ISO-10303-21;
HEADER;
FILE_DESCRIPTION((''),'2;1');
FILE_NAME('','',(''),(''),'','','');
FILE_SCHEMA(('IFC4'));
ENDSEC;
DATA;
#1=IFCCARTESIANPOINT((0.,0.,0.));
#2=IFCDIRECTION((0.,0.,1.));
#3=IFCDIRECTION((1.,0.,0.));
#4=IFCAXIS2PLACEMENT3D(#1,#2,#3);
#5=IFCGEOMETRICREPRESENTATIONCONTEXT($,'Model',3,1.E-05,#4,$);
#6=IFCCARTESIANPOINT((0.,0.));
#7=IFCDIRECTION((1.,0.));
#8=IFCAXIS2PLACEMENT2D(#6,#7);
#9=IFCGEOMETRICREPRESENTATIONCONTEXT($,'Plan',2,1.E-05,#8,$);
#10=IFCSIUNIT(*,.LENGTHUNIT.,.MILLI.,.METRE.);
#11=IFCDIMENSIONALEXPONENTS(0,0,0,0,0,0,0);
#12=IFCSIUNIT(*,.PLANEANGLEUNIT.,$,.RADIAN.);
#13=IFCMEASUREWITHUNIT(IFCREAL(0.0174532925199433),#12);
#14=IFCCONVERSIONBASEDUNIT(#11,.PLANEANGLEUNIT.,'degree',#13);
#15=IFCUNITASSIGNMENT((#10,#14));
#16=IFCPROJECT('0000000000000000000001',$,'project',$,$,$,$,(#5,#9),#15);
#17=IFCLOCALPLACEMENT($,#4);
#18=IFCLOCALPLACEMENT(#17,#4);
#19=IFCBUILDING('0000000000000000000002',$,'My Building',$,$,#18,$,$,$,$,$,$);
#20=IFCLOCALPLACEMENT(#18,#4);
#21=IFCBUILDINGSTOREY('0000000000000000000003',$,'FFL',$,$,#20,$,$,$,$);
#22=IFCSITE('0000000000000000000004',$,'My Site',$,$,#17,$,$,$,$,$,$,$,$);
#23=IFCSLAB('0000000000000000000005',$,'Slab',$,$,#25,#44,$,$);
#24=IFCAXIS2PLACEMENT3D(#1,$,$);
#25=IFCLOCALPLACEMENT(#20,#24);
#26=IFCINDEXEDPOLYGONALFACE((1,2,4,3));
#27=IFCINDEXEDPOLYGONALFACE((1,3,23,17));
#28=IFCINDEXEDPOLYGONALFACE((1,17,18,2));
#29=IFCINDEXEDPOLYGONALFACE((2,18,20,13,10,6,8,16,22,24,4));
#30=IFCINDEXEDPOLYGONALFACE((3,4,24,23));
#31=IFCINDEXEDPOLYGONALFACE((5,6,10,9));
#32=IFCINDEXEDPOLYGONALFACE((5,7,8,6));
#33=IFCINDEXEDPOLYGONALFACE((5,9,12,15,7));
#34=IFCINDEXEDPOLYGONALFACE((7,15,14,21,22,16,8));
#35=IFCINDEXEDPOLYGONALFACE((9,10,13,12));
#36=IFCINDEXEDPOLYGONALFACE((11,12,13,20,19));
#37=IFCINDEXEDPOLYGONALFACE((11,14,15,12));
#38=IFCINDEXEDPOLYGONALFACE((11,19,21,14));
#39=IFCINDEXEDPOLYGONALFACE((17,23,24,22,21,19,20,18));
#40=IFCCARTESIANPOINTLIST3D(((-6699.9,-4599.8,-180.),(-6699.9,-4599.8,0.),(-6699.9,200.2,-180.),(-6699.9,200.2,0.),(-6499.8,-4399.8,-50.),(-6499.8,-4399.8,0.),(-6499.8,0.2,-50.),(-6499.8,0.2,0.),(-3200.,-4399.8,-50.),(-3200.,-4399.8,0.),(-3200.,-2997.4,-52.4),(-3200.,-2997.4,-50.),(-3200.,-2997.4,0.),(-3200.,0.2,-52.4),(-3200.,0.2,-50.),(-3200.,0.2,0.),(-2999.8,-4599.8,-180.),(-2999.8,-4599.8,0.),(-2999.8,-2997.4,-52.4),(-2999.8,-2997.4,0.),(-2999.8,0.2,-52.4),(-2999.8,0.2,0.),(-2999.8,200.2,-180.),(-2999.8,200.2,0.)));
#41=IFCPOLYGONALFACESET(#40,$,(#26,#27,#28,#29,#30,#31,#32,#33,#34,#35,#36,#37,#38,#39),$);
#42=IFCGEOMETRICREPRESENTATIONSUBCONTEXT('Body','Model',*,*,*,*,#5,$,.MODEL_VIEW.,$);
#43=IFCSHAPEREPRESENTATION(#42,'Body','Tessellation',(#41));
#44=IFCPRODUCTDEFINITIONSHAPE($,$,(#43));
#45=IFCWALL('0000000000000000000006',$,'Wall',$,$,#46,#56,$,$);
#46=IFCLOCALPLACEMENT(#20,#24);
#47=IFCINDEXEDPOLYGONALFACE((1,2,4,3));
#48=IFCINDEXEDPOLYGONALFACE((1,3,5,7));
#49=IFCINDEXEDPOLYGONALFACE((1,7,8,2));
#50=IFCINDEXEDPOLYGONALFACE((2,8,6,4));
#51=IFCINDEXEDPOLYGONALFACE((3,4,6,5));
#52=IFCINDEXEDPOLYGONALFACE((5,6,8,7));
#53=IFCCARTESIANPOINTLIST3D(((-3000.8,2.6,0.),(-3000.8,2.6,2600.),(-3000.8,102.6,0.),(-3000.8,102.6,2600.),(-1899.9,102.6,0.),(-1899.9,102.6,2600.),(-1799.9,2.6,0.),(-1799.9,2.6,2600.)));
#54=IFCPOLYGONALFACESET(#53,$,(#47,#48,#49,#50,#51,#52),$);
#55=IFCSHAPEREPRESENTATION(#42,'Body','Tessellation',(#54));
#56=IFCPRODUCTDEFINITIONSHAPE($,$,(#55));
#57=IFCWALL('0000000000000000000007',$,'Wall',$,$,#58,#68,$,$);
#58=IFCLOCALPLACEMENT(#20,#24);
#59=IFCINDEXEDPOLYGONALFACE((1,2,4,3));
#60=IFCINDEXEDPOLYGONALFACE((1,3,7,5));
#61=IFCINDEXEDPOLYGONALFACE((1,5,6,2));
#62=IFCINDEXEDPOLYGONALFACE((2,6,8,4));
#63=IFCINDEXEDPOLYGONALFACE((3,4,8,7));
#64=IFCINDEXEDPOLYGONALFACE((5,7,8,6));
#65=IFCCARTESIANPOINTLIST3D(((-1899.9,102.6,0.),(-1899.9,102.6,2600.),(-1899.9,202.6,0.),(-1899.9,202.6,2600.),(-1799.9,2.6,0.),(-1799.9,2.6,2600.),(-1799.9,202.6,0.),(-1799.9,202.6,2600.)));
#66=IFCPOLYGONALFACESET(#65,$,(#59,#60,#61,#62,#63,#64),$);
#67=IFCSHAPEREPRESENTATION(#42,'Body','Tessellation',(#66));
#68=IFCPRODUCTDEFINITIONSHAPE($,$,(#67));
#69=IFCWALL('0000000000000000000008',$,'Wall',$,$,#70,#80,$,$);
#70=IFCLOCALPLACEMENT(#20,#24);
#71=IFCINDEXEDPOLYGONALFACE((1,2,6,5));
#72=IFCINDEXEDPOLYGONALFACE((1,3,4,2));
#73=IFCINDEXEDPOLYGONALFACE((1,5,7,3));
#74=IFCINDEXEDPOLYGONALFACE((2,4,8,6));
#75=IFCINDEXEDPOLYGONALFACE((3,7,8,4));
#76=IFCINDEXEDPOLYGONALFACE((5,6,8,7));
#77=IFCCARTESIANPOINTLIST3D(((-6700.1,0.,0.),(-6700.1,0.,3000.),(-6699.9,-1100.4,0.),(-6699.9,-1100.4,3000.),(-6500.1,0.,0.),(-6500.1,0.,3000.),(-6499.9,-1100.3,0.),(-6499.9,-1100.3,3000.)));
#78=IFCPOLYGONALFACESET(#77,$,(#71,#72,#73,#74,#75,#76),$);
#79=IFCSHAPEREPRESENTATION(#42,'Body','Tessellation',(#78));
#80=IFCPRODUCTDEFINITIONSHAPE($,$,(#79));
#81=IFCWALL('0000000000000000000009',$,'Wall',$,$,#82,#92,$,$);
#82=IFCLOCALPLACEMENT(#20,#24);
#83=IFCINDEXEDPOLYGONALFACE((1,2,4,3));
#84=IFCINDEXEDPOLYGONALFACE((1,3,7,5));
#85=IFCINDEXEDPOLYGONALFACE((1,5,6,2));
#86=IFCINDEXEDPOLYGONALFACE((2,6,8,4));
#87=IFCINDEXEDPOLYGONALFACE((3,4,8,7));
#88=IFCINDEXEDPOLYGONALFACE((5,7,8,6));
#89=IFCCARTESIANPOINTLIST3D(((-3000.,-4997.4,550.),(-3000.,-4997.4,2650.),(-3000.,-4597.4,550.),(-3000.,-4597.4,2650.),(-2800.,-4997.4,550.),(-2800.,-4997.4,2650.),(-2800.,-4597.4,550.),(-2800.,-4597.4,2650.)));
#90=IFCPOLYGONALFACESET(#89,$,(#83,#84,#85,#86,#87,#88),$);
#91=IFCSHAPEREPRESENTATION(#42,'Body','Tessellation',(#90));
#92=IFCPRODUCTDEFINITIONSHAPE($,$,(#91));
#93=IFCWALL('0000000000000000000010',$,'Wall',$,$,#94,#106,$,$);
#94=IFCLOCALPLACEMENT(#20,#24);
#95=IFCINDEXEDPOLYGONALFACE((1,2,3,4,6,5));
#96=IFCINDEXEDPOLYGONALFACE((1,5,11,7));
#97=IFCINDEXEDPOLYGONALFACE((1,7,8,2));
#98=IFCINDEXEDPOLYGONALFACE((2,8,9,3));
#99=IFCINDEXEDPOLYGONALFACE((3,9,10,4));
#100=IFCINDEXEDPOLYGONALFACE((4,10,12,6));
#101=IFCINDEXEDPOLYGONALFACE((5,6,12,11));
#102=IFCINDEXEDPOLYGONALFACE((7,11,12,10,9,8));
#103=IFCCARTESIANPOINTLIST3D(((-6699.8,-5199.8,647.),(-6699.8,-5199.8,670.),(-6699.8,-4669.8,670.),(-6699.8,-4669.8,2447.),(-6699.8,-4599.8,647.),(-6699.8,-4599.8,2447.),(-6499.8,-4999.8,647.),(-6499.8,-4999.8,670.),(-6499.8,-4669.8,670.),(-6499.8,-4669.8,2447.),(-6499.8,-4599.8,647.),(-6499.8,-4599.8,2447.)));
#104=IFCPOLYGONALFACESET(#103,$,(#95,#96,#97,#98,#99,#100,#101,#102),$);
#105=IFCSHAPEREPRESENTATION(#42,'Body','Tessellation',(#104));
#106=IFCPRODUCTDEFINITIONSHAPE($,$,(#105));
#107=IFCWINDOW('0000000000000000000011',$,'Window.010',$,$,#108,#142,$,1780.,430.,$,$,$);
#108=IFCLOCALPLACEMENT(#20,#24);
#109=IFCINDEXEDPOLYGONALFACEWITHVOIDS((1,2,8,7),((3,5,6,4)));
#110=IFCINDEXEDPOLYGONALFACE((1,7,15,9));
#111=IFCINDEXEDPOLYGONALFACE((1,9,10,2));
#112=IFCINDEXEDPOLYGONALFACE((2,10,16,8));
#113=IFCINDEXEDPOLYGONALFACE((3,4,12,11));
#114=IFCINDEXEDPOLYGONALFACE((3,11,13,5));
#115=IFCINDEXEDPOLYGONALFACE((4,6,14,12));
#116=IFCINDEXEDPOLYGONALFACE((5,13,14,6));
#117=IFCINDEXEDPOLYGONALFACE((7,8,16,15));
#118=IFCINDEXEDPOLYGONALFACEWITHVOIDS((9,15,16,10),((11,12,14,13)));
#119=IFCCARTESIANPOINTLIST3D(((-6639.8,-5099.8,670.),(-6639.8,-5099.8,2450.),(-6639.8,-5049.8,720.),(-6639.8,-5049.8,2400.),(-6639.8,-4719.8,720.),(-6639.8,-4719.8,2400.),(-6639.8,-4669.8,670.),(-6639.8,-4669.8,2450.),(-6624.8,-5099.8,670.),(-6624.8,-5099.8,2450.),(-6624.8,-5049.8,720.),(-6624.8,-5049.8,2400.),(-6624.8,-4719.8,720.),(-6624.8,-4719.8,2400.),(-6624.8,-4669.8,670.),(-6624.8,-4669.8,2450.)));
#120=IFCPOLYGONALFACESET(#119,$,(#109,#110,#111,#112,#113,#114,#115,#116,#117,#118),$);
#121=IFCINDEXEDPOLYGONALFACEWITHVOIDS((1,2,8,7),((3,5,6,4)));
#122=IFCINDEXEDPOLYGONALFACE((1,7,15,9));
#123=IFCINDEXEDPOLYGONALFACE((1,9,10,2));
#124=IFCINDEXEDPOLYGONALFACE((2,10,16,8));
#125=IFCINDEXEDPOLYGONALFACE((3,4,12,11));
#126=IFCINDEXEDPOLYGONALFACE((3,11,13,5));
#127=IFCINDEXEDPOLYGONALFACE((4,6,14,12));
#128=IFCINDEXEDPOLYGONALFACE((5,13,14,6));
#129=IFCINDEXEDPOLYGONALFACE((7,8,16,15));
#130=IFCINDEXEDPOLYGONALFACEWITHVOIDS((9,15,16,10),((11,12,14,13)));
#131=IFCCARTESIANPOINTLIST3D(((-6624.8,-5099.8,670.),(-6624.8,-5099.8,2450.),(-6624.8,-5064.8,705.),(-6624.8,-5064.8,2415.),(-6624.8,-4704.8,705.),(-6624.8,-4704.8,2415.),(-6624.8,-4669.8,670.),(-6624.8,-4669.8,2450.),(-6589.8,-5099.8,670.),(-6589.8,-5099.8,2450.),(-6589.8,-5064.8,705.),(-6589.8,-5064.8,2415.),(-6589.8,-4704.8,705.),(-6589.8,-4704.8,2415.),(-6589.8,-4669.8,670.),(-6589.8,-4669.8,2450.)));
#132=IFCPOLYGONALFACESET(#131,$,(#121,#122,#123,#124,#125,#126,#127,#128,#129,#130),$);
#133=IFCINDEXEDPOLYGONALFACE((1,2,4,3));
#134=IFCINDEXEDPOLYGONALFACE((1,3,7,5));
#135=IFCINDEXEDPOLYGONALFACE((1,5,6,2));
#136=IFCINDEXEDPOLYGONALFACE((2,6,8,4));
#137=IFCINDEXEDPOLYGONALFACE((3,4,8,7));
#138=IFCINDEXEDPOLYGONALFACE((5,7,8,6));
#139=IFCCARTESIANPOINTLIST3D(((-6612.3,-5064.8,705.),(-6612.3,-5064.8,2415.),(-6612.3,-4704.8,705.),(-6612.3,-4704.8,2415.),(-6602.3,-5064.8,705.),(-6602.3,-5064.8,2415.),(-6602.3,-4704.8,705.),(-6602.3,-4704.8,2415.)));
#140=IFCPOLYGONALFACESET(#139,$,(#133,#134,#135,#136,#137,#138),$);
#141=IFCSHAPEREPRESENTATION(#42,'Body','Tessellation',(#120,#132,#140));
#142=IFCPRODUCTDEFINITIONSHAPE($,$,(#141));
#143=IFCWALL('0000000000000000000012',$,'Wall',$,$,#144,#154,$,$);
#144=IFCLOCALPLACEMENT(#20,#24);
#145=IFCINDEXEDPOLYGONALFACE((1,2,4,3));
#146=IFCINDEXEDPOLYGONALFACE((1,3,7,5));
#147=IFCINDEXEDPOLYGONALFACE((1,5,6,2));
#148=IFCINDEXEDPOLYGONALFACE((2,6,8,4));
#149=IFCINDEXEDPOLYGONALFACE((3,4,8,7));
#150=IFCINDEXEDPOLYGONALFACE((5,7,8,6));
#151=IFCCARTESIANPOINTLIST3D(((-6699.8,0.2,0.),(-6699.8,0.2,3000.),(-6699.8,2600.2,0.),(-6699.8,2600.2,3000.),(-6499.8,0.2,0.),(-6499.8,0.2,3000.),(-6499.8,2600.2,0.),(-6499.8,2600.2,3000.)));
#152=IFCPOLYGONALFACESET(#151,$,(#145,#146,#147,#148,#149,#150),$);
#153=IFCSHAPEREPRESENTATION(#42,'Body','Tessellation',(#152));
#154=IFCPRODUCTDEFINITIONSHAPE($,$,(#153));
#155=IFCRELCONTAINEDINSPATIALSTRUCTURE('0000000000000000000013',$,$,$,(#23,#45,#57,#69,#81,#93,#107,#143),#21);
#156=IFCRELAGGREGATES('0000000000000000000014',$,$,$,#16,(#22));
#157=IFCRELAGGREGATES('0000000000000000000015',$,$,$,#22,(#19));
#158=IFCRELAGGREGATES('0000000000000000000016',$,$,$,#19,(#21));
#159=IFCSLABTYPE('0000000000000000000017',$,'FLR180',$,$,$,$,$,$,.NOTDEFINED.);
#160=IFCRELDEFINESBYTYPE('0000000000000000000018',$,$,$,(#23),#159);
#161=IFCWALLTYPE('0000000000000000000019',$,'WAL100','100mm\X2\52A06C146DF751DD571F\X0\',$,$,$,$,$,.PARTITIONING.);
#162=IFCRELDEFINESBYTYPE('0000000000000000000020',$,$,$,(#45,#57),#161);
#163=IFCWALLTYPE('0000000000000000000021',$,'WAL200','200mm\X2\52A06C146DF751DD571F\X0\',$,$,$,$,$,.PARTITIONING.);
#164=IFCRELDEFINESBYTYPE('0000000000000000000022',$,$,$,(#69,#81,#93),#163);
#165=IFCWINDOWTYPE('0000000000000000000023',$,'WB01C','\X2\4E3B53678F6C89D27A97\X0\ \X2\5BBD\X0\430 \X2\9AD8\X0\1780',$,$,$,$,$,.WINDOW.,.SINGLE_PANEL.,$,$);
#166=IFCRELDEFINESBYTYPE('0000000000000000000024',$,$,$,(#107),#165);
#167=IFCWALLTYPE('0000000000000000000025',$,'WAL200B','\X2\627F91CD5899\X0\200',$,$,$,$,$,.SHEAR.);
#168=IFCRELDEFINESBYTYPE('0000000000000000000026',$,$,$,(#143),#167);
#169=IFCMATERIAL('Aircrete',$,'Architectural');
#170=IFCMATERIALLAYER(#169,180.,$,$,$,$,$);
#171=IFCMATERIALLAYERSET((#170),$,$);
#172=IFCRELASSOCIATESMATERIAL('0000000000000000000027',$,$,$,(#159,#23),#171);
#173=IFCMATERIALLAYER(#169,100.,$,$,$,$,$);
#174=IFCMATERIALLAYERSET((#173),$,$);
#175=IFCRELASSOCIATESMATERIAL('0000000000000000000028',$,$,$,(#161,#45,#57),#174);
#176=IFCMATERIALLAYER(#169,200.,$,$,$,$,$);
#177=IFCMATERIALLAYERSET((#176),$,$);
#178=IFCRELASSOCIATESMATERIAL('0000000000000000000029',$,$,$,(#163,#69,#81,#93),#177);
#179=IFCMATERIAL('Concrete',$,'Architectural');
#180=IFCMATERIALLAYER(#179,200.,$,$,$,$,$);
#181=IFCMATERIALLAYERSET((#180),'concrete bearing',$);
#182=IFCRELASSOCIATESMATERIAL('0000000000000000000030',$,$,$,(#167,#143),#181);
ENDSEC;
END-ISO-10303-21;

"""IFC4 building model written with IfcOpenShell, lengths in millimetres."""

from ifc_helpers import new_model, entity, si_unit, converted_unit, frame, origin_with_axes, origin_2d_with_axis, place, context, subcontext, project, spatial, line, indexed_curve, outline, extrude, shape, source, transform, mapped, material, layer, layer_set, layer_usage, type_object, type_shapes, element, fill, save


model = new_model("IFC4")

# Units and contexts
model_context = context("Model", 3, precision=1e-05, world=origin_with_axes())
plan_context = context("Plan", 2, precision=1e-05, world=origin_2d_with_axis())
body_context_1 = subcontext(model_context, "Body", "Model", "MODEL_VIEW")
body_context_2 = subcontext(plan_context, "Body", "Plan", "PLAN_VIEW")
ifc_project = project(units=[si_unit("LENGTHUNIT", "METRE", prefix="MILLI"), converted_unit("PLANEANGLEUNIT", "degree", entity("IfcReal", 0.0174532925199433), si_unit("PLANEANGLEUNIT", "RADIAN"), dimensions=[0, 0, 0, 0, 0, 0, 0])], contexts=[model_context, plan_context])

# Site, building, storey
site_placement = place(None, origin_with_axes())
site = spatial("IfcSite", under=ifc_project, at=site_placement, Name="My Site")
building_placement = place(site_placement, origin_with_axes())
building = spatial("IfcBuilding", under=site, at=building_placement, Name="My Building")
storey_placement = place(building_placement, origin_with_axes())
storey = spatial("IfcBuildingStorey", under=building, at=storey_placement, Name="FFL")

# Slab, openings
ifc_material_1 = material(Name="Aircrete", Category="Architectural")
ifc_layer_1 = layer(ifc_material_1, 180.0)
ifc_layer_set_1 = layer_set([ifc_layer_1])
ifc_layer_usage_1 = layer_usage(ifc_layer_set_1, "AXIS3", "POSITIVE", 0.0)
slab_type = type_object("IfcSlabType", Name="FLR180", PredefinedType="NOTDEFINED", material=ifc_layer_set_1)
slab_1_placement = place(storey_placement, frame((-6499.8, -4399.8, -180.0), z_axis=(0.0, 0.0, 1.0), x_axis=(1.0, 0.0, 0.0)))
slab_1 = element("IfcSlab", 1, at=slab_1_placement, inside=storey, type_object=slab_type, material=ifc_layer_usage_1, Name="Slab", context=body_context_1, shape_type="SweptSolid", body=[
    extrude(outline(indexed_curve([(-200.1, -200.0), (3500.0, -200.0), (3500.0, 4600.0), (-200.1, 4600.0), (-200.1, -200.0)])), None, (0.0, 0.0, 1.0), 180.0),
])
opening_1_placement = place(slab_1_placement, frame((0.0, 0.0, 130.0), z_axis=(0.0, 0.0, 1.0), x_axis=(1.0, 0.0, 0.0)))
element("IfcOpeningElement", 2, at=opening_1_placement, cuts=slab_1, PredefinedType="OPENING", context=body_context_1, shape_type="SweptSolid", body=[
    extrude(outline(indexed_curve([(0.0, 4400.0), (3299.8, 4400.0), (3299.8, 0.0), (0.0, 0.0), (0.0, 4400.0)])), origin_with_axes(), (0.0, 0.0, 1.0), 100.0),
])
opening_2_placement = place(slab_1_placement, frame((3299.8, 1402.4, 127.6), z_axis=(0.0, 0.0, 1.0), x_axis=(1.0, 0.0, 0.0)))
element("IfcOpeningElement", 3, at=opening_2_placement, cuts=slab_1, PredefinedType="OPENING", context=body_context_1, shape_type="SweptSolid", body=[
    extrude(outline(indexed_curve([(0.0, 2997.6), (200.3, 2997.6), (200.3, 0.0), (0.0, 0.0), (0.0, 2997.6)])), origin_with_axes(), (0.0, 0.0, 1.0), 100.0),
])

# Walls
ifc_layer_2 = layer(ifc_material_1, 100.0)
ifc_layer_set_2 = layer_set([ifc_layer_2])
ifc_layer_usage_2 = layer_usage(ifc_layer_set_2, "AXIS2", "POSITIVE", 0.0)
wall_type_1 = type_object("IfcWallType", Name="WAL100", Description="100mm加气混凝土", PredefinedType="PARTITIONING", material=ifc_layer_set_2)
wall_1_placement = place(storey_placement, frame((-3000.8, 2.6, 0.0), z_axis=(0.0, 0.0, 1.0), x_axis=(1.0, 0.0, 0.0)))
element("IfcWall", 4, at=wall_1_placement, inside=storey, type_object=wall_type_1, material=ifc_layer_usage_2, Name="Wall", context=body_context_1, shape_type="SweptSolid", body=[
    extrude(outline(indexed_curve([(0.0, 0.0), (0.0, 100.0), (1100.9, 100.0), (1200.9, 0.0)], segments=[line(1, 2, 3, 4, 1)])), origin_with_axes(), (0.0, 0.0, 1.0), 2600.0),
])
ifc_layer_usage_3 = layer_usage(ifc_layer_set_2, "AXIS2", "POSITIVE", 0.0)
wall_2_placement = place(storey_placement, frame((-1799.9, 2.6, 0.0), z_axis=(0.0, 0.0, 1.0), x_axis=(0.0, 1.0, 0.0)))
element("IfcWall", 5, at=wall_2_placement, inside=storey, type_object=wall_type_1, material=ifc_layer_usage_3, Name="Wall", context=body_context_1, shape_type="SweptSolid", body=[
    extrude(outline(indexed_curve([(0.0, 0.0), (100.0, 100.0), (200.0, 100.0), (200.0, 0.0)], segments=[line(1, 2, 3, 4, 1)])), origin_with_axes(), (0.0, 0.0, 1.0), 2600.0),
])
ifc_layer_3 = layer(ifc_material_1, 200.0)
ifc_layer_set_3 = layer_set([ifc_layer_3])
ifc_layer_usage_4 = layer_usage(ifc_layer_set_3, "AXIS2", "NEGATIVE", 0.0)
wall_type_2 = type_object("IfcWallType", Name="WAL200", Description="200mm加气混凝土", PredefinedType="PARTITIONING", material=ifc_layer_set_3)
wall_3_placement = place(storey_placement, frame((-6699.9, -1100.4, 0.0), z_axis=(0.0, 0.0, 1.0), x_axis=(-0.000172, 1.0, 0.0)))
element("IfcWall", 6, at=wall_3_placement, inside=storey, type_object=wall_type_2, material=ifc_layer_usage_4, Name="Wall", context=body_context_1, shape_type="SweptSolid", body=[
    extrude(outline(indexed_curve([(0.0, -200.0), (0.0, 0.0), (1100.3, 0.0), (1100.3, -200.0)], segments=[line(1, 2, 3, 4, 1)])), origin_with_axes(), (0.0, 0.0, 1.0), 3000.0),
])
ifc_layer_usage_5 = layer_usage(ifc_layer_set_3, "AXIS2", "NEGATIVE", 0.0)
wall_4_placement = place(storey_placement, frame((-3000.0, -4997.4, 550.0), z_axis=(0.0, 0.0, 1.0), x_axis=(0.0, 1.0, 0.0)))
element("IfcWall", 7, at=wall_4_placement, inside=storey, type_object=wall_type_2, material=ifc_layer_usage_5, Name="Wall", context=body_context_1, shape_type="SweptSolid", body=[
    extrude(outline(indexed_curve([(0.0, -200.0), (0.0, 0.0), (400.0, 0.0), (400.0, -200.0)], segments=[line(1, 2, 3, 4, 1)])), origin_with_axes(), (0.0, 0.0, 1.0), 2100.0),
])

# Wall, opening, window
ifc_layer_usage_6 = layer_usage(ifc_layer_set_3, "AXIS2", "NEGATIVE", 0.0)
wall_5_placement = place(storey_placement, frame((-6499.8, -4599.8, 647.0), z_axis=(0.0, 0.0, 1.0), x_axis=(-0.000001, -1.0, 0.0)))
wall_5 = element("IfcWall", 8, at=wall_5_placement, inside=storey, type_object=wall_type_2, material=ifc_layer_usage_6, Name="Wall", context=body_context_1, shape_type="SweptSolid", body=[
    extrude(outline(indexed_curve([(0.0, -200.0), (0.0, 0.0), (400.0, 0.0), (600.0, -200.0)], segments=[line(1, 2, 3, 4, 1)])), origin_with_axes(), (0.0, 0.0, 1.0), 1800.0),
])
shared_shape_1 = source(origin_with_axes(), body_context_1, "Body", "SweptSolid", [
    extrude(outline(indexed_curve([(0.0, 1780.0), (599.5, 1780.0), (599.5, 0.0), (0.0, 0.0), (0.0, 1780.0)])), frame((0.0, -600.0, 0.0), z_axis=(0.0, -1.0, 0.0), x_axis=(1.0, 0.0, 0.0)), (0.0, 0.0, -1.0), 1200.0),
])
opening_3_placement = place(wall_5_placement, frame((70.0, -190.0, 23.0), z_axis=(0.0, 0.0, 1.0), x_axis=(1.0, 0.0, 0.0)))
opening_3 = element("IfcOpeningElement", 9, at=opening_3_placement, cuts=wall_5, PredefinedType="OPENING", context=body_context_1, shape_type="MappedRepresentation", body=[
    mapped(shared_shape_1, transform((0.0, 0.0, 0.0), x_axis=(1.0, 0.0, 0.0), y_axis=(0.0, 1.0, 0.0), z_axis=(0.0, 0.0, 1.0), scale=1.0)),
])
window_type_1 = type_object("IfcWindowType", Name="WB01C", Description="主卧转角窗 宽430 高1780", PartitioningType="SINGLE_PANEL", PredefinedType="WINDOW")
shared_shape_2 = source(origin_with_axes(), body_context_1, "Body", "SweptSolid", [
    extrude(outline(indexed_curve([(0.0, 1780.0), (430.0, 1780.0), (430.0, 0.0), (0.0, 0.0), (0.0, 1780.0)]), holes=[indexed_curve([(50.0, 1730.0), (380.0, 1730.0), (380.0, 50.0), (50.0, 50.0), (50.0, 1730.0)])]), frame((0.0, 50.0, 0.0), z_axis=(0.0, -1.0, 0.0), x_axis=(1.0, 0.0, 0.0)), (0.0, 0.0, -1.0), 15.0),
    extrude(outline(indexed_curve([(0.0, 0.0), (430.0, 0.0), (430.0, 1780.0), (0.0, 1780.0)], segments=[line(1, 2, 3, 4, 1)]), holes=[indexed_curve([(35.0, 35.0), (395.0, 35.0), (395.0, 1745.0), (35.0, 1745.0)], segments=[line(1, 2, 3, 4, 1)])]), frame((0.0, 65.0, 0.0), z_axis=(0.0, -1.0, 0.0), x_axis=(1.0, 0.0, 0.0)), (0.0, 0.0, -1.0), 35.0),
    extrude(outline(indexed_curve([(35.0, 35.0), (395.0, 35.0), (395.0, 1745.0), (35.0, 1745.0)], segments=[line(1, 2, 3, 4, 1)])), frame((0.0, 77.5, 0.0), z_axis=(0.0, -1.0, 0.0), x_axis=(1.0, 0.0, 0.0)), (0.0, 0.0, -1.0), 10.0),
])
shared_shape_3 = source(origin_with_axes(), body_context_2, "Body", "Curve2D", [
    entity("IfcIndexedPolyCurve", entity("IfcCartesianPointList2D", [[50.0, 50.0], [380.0, 50.0]])),
    entity("IfcIndexedPolyCurve", entity("IfcCartesianPointList2D", [[0.0, 100.0], [0.0, 100.0], [0.0, 65.0], [50.0, 65.0], [50.0, 50.0], [0.0, 50.0]]), [entity("IfcLineIndex", [1, 2, 3, 4, 5, 6, 1])]),
    entity("IfcIndexedPolyCurve", entity("IfcCartesianPointList2D", [[430.0, 100.0], [430.0, 100.0], [430.0, 65.0], [380.0, 65.0], [380.0, 50.0], [430.0, 50.0]]), [entity("IfcLineIndex", [1, 2, 3, 4, 5, 6, 1])]),
    entity("IfcIndexedPolyCurve", entity("IfcCartesianPointList2D", [[0.0, 65.0], [35.0, 65.0], [35.0, 100.0], [0.0, 100.0]]), [entity("IfcLineIndex", [1, 2, 3, 4, 1])]),
    entity("IfcIndexedPolyCurve", entity("IfcCartesianPointList2D", [[430.0, 65.0], [395.0, 65.0], [395.0, 100.0], [430.0, 100.0]]), [entity("IfcLineIndex", [1, 2, 3, 4, 1])]),
    entity("IfcIndexedPolyCurve", entity("IfcCartesianPointList2D", [[35.0, 65.0], [395.0, 65.0]])),
    entity("IfcIndexedPolyCurve", entity("IfcCartesianPointList2D", [[35.0, 100.0], [395.0, 100.0]])),
    entity("IfcIndexedPolyCurve", entity("IfcCartesianPointList2D", [[35.0, 82.5], [395.0, 82.5]])),
])
type_shapes(window_type_1, [shared_shape_2, shared_shape_3])
window_1_placement = place(opening_3_placement, frame((0.0, 0.0, 0.0), z_axis=(0.0, 0.0, 1.0), x_axis=(1.0, 0.0, 0.0)))
window_1 = element("IfcWindow", 10, at=window_1_placement, inside=storey, type_object=window_type_1, Name="Window.010", OverallHeight=1780.0, OverallWidth=430.0, shapes=[
    shape(body_context_1, "Body", "MappedRepresentation", [mapped(shared_shape_2, transform((0.0, 0.0, 0.0), x_axis=(1.0, 0.0, 0.0), y_axis=(0.0, 1.0, 0.0), z_axis=(0.0, 0.0, 1.0), scale=1.0))]),
    shape(body_context_2, "Body", "MappedRepresentation", [mapped(shared_shape_3, transform((0.0, 0.0, 0.0), x_axis=(1.0, 0.0, 0.0), y_axis=(0.0, 1.0, 0.0), z_axis=(0.0, 0.0, 1.0), scale=1.0))]),
])
fill(opening_3, window_1)

# Wall
ifc_material_2 = material(Name="Concrete", Category="Architectural")
ifc_layer_4 = layer(ifc_material_2, 200.0)
ifc_layer_set_4 = layer_set([ifc_layer_4], Name="concrete bearing")
ifc_layer_usage_7 = layer_usage(ifc_layer_set_4, "AXIS2", "NEGATIVE", 0.0)
wall_type_3 = type_object("IfcWallType", Name="WAL200B", Description="承重墙200", PredefinedType="SHEAR", material=ifc_layer_set_4)
wall_6_placement = place(storey_placement, frame((-6699.8, 0.2, 0.0), z_axis=(0.0, 0.0, 1.0), x_axis=(0.0, 1.0, 0.0)))
element("IfcWall", 11, at=wall_6_placement, inside=storey, type_object=wall_type_3, material=ifc_layer_usage_7, Name="Wall", context=body_context_1, shape_type="SweptSolid", body=[
    extrude(outline(indexed_curve([(0.0, -200.0), (0.0, 0.0), (2600.0, 0.0), (2600.0, -200.0)], segments=[line(1, 2, 3, 4, 1)])), origin_with_axes(), (0.0, 0.0, 1.0), 3000.0),
])

save(model, "model.ifc")
